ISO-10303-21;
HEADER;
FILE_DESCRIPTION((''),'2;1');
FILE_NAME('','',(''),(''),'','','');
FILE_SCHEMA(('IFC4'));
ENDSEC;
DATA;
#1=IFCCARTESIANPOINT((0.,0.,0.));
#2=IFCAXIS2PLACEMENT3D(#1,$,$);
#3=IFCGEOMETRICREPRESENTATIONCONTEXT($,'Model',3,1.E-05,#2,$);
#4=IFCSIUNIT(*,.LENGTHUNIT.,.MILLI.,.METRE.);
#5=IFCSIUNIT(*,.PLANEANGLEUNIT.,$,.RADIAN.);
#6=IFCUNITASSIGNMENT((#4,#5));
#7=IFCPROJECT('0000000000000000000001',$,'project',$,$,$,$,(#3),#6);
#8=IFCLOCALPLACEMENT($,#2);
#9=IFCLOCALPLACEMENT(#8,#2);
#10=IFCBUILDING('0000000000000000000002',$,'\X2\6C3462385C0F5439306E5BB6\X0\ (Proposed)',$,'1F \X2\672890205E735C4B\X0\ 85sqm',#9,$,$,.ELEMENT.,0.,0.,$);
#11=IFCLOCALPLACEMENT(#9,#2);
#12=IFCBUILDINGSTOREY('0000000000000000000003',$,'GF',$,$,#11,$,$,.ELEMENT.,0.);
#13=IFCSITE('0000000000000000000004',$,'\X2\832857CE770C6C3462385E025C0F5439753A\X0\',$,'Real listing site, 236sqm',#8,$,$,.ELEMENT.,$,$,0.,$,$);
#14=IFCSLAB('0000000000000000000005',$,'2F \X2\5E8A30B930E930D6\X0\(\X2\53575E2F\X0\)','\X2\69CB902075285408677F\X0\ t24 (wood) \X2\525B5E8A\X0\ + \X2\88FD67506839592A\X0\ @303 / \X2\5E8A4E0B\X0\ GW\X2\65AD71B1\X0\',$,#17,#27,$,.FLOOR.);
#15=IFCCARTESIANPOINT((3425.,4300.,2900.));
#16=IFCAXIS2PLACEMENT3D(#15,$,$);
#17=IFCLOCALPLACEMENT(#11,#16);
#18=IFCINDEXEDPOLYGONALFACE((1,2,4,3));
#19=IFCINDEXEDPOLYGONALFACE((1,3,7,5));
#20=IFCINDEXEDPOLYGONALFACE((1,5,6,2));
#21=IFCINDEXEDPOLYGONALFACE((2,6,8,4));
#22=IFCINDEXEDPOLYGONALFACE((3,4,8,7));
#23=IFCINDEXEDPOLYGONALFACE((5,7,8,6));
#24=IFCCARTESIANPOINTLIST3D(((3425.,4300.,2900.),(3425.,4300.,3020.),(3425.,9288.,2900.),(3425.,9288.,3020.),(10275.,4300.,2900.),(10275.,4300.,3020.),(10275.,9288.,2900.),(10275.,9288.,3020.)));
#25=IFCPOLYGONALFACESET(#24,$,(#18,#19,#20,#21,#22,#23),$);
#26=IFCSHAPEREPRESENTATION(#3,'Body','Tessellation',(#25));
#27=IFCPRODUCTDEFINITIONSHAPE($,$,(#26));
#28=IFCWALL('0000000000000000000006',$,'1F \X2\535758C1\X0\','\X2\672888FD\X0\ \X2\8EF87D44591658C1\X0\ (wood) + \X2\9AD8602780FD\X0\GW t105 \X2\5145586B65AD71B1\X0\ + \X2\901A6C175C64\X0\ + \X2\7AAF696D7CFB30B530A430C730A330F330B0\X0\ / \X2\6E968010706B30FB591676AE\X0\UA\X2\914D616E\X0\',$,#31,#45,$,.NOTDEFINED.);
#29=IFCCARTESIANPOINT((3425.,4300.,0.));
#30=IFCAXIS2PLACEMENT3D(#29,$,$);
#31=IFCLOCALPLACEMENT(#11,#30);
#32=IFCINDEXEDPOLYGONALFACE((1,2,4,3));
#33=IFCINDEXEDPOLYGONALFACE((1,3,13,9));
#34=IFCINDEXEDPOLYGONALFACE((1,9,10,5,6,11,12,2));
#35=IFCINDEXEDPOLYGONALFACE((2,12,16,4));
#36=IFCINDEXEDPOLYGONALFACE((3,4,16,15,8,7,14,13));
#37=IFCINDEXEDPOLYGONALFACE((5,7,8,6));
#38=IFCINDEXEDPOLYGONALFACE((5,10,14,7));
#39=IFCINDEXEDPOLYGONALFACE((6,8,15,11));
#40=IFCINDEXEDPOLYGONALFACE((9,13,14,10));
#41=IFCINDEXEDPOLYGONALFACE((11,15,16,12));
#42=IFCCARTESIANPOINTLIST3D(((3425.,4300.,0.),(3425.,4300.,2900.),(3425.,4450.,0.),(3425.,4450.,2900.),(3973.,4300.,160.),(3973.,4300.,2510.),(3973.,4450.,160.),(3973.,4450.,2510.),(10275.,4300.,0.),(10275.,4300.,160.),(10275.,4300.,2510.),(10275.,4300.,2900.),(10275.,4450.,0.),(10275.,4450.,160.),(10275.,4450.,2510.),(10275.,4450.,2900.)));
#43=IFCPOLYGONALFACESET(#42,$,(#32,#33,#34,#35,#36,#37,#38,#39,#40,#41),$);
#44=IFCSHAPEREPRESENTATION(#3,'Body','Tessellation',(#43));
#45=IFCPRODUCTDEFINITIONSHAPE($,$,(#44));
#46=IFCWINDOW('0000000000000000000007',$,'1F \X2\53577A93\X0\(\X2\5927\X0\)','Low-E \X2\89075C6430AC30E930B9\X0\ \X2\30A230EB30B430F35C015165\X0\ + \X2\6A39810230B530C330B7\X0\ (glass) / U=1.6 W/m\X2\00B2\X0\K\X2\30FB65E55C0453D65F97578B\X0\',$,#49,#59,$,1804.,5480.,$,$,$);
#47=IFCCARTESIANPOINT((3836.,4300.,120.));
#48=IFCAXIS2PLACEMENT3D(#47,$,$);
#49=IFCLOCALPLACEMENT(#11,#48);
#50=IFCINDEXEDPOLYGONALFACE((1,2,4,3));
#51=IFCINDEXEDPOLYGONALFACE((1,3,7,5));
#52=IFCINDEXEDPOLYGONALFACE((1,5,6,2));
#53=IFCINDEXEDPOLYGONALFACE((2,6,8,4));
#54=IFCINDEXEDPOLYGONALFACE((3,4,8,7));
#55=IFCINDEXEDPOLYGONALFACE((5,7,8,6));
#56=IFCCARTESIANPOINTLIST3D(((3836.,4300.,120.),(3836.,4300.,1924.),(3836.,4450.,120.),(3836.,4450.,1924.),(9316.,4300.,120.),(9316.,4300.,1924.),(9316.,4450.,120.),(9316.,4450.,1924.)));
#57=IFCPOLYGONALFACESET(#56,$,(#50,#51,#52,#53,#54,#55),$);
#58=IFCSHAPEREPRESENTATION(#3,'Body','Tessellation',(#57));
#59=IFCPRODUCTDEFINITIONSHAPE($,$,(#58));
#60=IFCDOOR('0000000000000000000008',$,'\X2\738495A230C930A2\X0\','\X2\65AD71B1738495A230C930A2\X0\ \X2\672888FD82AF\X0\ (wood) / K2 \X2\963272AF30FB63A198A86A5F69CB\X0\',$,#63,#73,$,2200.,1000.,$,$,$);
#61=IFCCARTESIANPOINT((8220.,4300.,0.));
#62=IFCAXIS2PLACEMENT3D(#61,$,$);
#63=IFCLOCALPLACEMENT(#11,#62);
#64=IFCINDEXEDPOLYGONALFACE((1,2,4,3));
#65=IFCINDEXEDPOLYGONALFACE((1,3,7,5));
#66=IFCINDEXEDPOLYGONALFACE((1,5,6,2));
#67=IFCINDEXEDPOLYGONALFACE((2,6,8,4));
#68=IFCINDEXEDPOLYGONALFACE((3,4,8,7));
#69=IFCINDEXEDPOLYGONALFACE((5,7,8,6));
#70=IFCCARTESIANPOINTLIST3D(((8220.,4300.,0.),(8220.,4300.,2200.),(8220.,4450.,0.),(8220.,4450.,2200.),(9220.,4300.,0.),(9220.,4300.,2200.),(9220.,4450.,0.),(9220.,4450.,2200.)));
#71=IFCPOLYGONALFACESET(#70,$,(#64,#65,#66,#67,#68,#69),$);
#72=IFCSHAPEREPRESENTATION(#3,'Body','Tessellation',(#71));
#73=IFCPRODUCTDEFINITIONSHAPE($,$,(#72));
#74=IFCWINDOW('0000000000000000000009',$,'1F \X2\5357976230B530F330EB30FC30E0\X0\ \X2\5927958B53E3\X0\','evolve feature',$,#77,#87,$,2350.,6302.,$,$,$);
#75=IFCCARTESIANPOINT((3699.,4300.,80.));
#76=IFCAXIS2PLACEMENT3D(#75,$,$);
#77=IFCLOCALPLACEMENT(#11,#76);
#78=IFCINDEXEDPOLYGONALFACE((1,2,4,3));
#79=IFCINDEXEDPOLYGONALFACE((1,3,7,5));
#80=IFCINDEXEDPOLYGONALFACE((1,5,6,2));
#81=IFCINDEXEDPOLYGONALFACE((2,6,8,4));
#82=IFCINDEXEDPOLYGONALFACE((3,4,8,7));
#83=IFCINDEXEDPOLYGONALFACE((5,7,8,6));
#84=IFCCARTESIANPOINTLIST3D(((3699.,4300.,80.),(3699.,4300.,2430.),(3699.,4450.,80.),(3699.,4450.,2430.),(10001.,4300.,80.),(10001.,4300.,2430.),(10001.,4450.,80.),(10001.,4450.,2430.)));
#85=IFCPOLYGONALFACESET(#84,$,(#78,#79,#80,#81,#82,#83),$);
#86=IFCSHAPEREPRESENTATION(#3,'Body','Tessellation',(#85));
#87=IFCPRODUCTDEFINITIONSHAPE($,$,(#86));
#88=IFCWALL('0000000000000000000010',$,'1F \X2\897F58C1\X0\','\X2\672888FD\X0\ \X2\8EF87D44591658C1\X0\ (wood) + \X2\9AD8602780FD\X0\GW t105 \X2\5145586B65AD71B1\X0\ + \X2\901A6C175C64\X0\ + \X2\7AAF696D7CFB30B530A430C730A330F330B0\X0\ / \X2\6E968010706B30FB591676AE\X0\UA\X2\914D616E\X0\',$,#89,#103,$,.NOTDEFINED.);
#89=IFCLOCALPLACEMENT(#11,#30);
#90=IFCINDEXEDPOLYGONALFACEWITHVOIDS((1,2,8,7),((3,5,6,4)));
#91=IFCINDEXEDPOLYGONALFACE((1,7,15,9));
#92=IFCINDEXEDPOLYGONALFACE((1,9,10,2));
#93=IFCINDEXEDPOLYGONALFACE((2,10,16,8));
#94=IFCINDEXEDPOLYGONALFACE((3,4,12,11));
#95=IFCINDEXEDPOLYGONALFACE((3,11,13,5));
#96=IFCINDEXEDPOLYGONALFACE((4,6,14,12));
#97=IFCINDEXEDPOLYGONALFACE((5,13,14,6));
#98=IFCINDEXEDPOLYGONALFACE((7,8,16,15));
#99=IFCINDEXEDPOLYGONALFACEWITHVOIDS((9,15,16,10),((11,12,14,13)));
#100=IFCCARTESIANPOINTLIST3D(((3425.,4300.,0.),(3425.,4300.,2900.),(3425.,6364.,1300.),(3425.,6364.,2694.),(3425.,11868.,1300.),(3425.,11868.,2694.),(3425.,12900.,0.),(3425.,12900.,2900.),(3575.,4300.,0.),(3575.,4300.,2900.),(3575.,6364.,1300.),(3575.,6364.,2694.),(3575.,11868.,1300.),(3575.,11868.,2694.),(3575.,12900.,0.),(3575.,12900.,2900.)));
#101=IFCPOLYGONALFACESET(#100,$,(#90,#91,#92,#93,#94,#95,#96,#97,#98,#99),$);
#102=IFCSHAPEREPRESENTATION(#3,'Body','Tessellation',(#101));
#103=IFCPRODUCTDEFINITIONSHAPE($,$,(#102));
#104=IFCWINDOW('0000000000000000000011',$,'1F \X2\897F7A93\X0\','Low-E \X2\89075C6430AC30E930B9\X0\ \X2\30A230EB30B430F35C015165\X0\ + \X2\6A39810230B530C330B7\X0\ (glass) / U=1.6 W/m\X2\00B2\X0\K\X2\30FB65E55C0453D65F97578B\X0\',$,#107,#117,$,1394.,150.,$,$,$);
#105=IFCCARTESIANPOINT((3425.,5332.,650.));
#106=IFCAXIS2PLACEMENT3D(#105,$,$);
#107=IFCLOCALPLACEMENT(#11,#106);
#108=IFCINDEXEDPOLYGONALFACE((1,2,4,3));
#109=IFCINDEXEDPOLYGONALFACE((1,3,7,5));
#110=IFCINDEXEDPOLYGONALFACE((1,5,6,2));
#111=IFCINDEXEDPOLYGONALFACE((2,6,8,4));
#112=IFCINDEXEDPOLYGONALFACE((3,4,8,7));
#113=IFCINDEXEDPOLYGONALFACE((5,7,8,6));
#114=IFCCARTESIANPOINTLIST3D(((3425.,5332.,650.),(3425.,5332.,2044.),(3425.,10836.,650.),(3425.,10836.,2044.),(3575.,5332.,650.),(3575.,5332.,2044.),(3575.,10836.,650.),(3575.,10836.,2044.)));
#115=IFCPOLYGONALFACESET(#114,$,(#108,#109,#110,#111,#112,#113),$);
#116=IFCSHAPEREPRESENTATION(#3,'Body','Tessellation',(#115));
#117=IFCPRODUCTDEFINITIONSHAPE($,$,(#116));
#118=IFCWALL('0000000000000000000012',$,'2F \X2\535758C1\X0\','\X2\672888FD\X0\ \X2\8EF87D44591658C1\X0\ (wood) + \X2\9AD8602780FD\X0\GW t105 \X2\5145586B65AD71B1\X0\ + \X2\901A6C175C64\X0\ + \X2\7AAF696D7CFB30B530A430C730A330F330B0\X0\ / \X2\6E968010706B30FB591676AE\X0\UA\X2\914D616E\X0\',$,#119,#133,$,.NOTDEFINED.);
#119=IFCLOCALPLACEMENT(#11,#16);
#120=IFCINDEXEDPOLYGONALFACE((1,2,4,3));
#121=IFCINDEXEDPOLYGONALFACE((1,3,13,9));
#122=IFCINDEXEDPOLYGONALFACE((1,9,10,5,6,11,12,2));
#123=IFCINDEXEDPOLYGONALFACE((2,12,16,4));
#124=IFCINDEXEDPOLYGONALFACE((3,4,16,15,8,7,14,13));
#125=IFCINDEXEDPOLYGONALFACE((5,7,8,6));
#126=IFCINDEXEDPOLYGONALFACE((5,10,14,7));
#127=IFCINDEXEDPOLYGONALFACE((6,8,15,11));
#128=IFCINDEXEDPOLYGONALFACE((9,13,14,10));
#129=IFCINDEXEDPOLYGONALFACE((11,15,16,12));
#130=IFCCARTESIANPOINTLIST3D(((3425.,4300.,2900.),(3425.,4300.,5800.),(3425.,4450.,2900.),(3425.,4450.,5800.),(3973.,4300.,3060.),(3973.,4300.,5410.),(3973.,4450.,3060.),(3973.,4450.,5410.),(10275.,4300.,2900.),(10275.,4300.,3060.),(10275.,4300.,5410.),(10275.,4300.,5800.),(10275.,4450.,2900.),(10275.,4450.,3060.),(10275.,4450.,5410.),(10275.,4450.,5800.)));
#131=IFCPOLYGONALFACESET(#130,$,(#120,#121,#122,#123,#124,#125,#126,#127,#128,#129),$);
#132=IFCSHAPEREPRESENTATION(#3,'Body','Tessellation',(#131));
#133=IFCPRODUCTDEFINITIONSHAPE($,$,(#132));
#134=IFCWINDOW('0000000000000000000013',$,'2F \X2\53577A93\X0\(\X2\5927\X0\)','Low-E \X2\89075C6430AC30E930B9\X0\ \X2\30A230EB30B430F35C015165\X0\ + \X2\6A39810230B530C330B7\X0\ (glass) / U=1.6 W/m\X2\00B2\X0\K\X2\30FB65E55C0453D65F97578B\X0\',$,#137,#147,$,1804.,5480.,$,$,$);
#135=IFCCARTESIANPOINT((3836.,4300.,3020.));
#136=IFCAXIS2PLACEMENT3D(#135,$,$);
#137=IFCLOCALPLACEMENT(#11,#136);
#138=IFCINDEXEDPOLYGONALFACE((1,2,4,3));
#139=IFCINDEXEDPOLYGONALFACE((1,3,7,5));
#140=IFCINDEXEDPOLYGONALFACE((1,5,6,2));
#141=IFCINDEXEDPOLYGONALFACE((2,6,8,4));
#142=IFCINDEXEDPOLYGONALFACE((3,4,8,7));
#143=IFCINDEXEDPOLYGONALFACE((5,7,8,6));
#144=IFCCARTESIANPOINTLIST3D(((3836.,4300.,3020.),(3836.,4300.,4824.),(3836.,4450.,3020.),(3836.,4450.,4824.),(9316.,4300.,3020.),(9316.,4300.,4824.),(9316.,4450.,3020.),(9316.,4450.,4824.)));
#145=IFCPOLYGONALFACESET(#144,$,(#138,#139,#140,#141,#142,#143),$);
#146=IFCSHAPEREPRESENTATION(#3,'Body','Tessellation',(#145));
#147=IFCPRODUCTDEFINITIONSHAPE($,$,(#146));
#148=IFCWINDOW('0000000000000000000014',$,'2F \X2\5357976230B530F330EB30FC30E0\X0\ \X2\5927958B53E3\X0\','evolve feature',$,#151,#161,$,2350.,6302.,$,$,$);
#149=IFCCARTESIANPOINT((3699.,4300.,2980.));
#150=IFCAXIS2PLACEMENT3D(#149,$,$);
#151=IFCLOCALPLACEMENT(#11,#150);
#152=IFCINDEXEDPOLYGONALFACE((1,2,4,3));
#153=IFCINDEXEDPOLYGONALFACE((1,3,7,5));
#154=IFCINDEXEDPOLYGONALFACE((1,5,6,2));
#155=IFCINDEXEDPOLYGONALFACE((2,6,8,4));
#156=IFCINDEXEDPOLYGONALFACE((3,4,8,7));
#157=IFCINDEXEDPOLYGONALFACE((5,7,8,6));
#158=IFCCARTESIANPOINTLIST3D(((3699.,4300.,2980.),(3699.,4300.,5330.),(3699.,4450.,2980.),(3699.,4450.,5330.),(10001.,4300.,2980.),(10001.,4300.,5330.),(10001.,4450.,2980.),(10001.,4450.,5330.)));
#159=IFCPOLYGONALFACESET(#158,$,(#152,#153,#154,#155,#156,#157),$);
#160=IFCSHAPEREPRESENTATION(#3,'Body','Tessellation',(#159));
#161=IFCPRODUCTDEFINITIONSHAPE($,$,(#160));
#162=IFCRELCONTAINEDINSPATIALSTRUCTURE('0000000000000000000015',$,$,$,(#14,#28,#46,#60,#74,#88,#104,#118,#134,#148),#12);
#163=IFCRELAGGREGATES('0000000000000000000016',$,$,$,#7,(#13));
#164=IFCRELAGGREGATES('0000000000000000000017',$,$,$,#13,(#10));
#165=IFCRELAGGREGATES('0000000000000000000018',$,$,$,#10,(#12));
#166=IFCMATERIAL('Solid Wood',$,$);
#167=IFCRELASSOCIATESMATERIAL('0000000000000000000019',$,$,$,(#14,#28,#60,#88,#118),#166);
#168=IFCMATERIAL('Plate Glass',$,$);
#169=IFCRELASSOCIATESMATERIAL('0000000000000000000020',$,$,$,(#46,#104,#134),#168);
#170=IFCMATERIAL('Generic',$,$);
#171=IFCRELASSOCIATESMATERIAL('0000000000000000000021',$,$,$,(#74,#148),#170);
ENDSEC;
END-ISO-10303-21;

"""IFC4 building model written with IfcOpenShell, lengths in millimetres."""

from ifc_helpers import new_model, si_unit, frame, frame_2d, origin, place, context, project, spatial, rectangle, extrude, material, element, fill, save


model = new_model("IFC4")

# Units and contexts
model_context = context("Model", 3, precision=1e-05, world=origin())
ifc_project = project(units=[si_unit("LENGTHUNIT", "METRE", prefix="MILLI"), si_unit("PLANEANGLEUNIT", "RADIAN")], contexts=[model_context])

# Site, building, storey
site_placement = place(None, origin())
site = spatial("IfcSite", under=ifc_project, at=site_placement, Name="茨城県水戸市小吹町", ObjectType="Real listing site, 236sqm", CompositionType="ELEMENT", RefElevation=0.0)
building_placement = place(site_placement, origin())
building = spatial("IfcBuilding", under=site, at=building_placement, Name="水戸小吹の家 (Proposed)", ObjectType="1F 木造平屋 85sqm", CompositionType="ELEMENT", ElevationOfRefHeight=0.0, ElevationOfTerrain=0.0)
storey_placement = place(building_placement, origin())
storey = spatial("IfcBuildingStorey", under=building, at=storey_placement, Name="GF", CompositionType="ELEMENT", Elevation=0.0)

# Slab
ifc_material_1 = material(Name="Solid Wood")
slab_1_placement = place(storey_placement, frame((3425.0, 4300.0, 2900.0)))
element("IfcSlab", 1, at=slab_1_placement, inside=storey, material=ifc_material_1, Name="2F 床スラブ(南帯)", Description="構造用合板 t24 (wood) 剛床 + 製材根太 @303 / 床下 GW断熱", PredefinedType="FLOOR", context=model_context, shape_type="SweptSolid", body=[
    extrude(rectangle(XDim=6850.0, YDim=4988.0, at=frame_2d((3425.0, 2494.0))), frame((3425.0, 4300.0, 2900.0)), (0.0, 0.0, 1.0), 120.0),
])
ifc_material_2 = material(Name="Generic")

# Wall, openings, windows, door
wall_1_placement = place(storey_placement, frame((3425.0, 4300.0, 0.0)))
wall_1 = element("IfcWall", 2, at=wall_1_placement, inside=storey, material=ifc_material_1, Name="1F 南壁", Description="木製 軸組外壁 (wood) + 高性能GW t105 充填断熱 + 通気層 + 窯業系サイディング / 準耐火・外皮UA配慮", PredefinedType="NOTDEFINED", context=model_context, shape_type="SweptSolid", body=[
    extrude(rectangle(XDim=6850.0, YDim=150.0, at=frame_2d((3425.0, 75.0))), frame((3425.0, 4300.0, 0.0)), (0.0, 0.0, 1.0), 2900.0),
])
opening_1_placement = place(storey_placement, frame((3836.0, 4300.0, 120.0)))
opening_1 = element("IfcOpeningElement", 3, at=opening_1_placement, cuts=wall_1, PredefinedType="NOTDEFINED", context=model_context, shape_type="SweptSolid", body=[
    extrude(rectangle(XDim=5480.0, YDim=150.0, at=frame_2d((2740.0, 75.0))), frame((3836.0, 4300.0, 120.0)), (0.0, 0.0, 1.0), 1804.0),
])
opening_2_placement = place(storey_placement, frame((8220.0, 4300.0, 0.0)))
opening_2 = element("IfcOpeningElement", 4, at=opening_2_placement, cuts=wall_1, PredefinedType="NOTDEFINED", context=model_context, shape_type="SweptSolid", body=[
    extrude(rectangle(XDim=1000.0, YDim=150.0, at=frame_2d((500.0, 75.0))), frame((8220.0, 4300.0, 0.0)), (0.0, 0.0, 1.0), 2200.0),
])
opening_3_placement = place(storey_placement, frame((3699.0, 4300.0, 80.0)))
opening_3 = element("IfcOpeningElement", 5, at=opening_3_placement, cuts=wall_1, PredefinedType="NOTDEFINED", context=model_context, shape_type="SweptSolid", body=[
    extrude(rectangle(XDim=6302.0, YDim=150.0, at=frame_2d((3151.0, 75.0))), frame((3699.0, 4300.0, 80.0)), (0.0, 0.0, 1.0), 2350.0),
])
ifc_material_3 = material(Name="Plate Glass")
window_1_placement = place(storey_placement, frame((3836.0, 4300.0, 120.0)))
window_1 = element("IfcWindow", 6, at=window_1_placement, inside=storey, material=ifc_material_3, Name="1F 南窓(大)", Description="Low-E 複層ガラス アルゴン封入 + 樹脂サッシ (glass) / U=1.6 W/m²K・日射取得型", OverallHeight=1804.0, OverallWidth=5480.0, context=model_context, shape_type="SweptSolid", body=[
    extrude(rectangle(XDim=5480.0, YDim=150.0, at=frame_2d((2740.0, 75.0))), frame((3836.0, 4300.0, 120.0)), (0.0, 0.0, 1.0), 1804.0),
])
fill(opening_1, window_1)
door_placement = place(storey_placement, frame((8220.0, 4300.0, 0.0)))
door = element("IfcDoor", 7, at=door_placement, inside=storey, material=ifc_material_1, Name="玄関ドア", Description="断熱玄関ドア 木製芯 (wood) / K2 防犯・採風機構", OverallHeight=2200.0, OverallWidth=1000.0, context=model_context, shape_type="SweptSolid", body=[
    extrude(rectangle(XDim=1000.0, YDim=150.0, at=frame_2d((500.0, 75.0))), frame((8220.0, 4300.0, 0.0)), (0.0, 0.0, 1.0), 2200.0),
])
fill(opening_2, door)
window_2_placement = place(storey_placement, frame((3699.0, 4300.0, 80.0)))
window_2 = element("IfcWindow", 8, at=window_2_placement, inside=storey, material=ifc_material_2, Name="1F 南面サンルーム 大開口", Description="evolve feature", OverallHeight=2350.0, OverallWidth=6302.0, context=model_context, shape_type="SweptSolid", body=[
    extrude(rectangle(XDim=6302.0, YDim=150.0, at=frame_2d((3151.0, 75.0))), frame((3699.0, 4300.0, 80.0)), (0.0, 0.0, 1.0), 2350.0),
])
fill(opening_3, window_2)

# Wall, opening, window
wall_2_placement = place(storey_placement, frame((3425.0, 4300.0, 0.0)))
wall_2 = element("IfcWall", 9, at=wall_2_placement, inside=storey, material=ifc_material_1, Name="1F 西壁", Description="木製 軸組外壁 (wood) + 高性能GW t105 充填断熱 + 通気層 + 窯業系サイディング / 準耐火・外皮UA配慮", PredefinedType="NOTDEFINED", context=model_context, shape_type="SweptSolid", body=[
    extrude(rectangle(XDim=150.0, YDim=8600.0, at=frame_2d((75.0, 4300.0))), frame((3425.0, 4300.0, 0.0)), (0.0, 0.0, 1.0), 2900.0),
])
opening_4_placement = place(storey_placement, frame((3425.0, 5332.0, 650.0)))
opening_4 = element("IfcOpeningElement", 10, at=opening_4_placement, cuts=wall_2, PredefinedType="NOTDEFINED", context=model_context, shape_type="SweptSolid", body=[
    extrude(rectangle(XDim=150.0, YDim=5504.0, at=frame_2d((75.0, 2752.0))), frame((3425.0, 5332.0, 650.0)), (0.0, 0.0, 1.0), 1394.0),
])
window_3_placement = place(storey_placement, frame((3425.0, 5332.0, 650.0)))
window_3 = element("IfcWindow", 11, at=window_3_placement, inside=storey, material=ifc_material_3, Name="1F 西窓", Description="Low-E 複層ガラス アルゴン封入 + 樹脂サッシ (glass) / U=1.6 W/m²K・日射取得型", OverallHeight=1394.0, OverallWidth=150.0, context=model_context, shape_type="SweptSolid", body=[
    extrude(rectangle(XDim=150.0, YDim=5504.0, at=frame_2d((75.0, 2752.0))), frame((3425.0, 5332.0, 650.0)), (0.0, 0.0, 1.0), 1394.0),
])
fill(opening_4, window_3)

# Wall, openings, windows
wall_3_placement = place(storey_placement, frame((3425.0, 4300.0, 2900.0)))
wall_3 = element("IfcWall", 12, at=wall_3_placement, inside=storey, material=ifc_material_1, Name="2F 南壁", Description="木製 軸組外壁 (wood) + 高性能GW t105 充填断熱 + 通気層 + 窯業系サイディング / 準耐火・外皮UA配慮", PredefinedType="NOTDEFINED", context=model_context, shape_type="SweptSolid", body=[
    extrude(rectangle(XDim=6850.0, YDim=150.0, at=frame_2d((3425.0, 75.0))), frame((3425.0, 4300.0, 2900.0)), (0.0, 0.0, 1.0), 2900.0),
])
opening_5_placement = place(storey_placement, frame((3836.0, 4300.0, 3020.0)))
opening_5 = element("IfcOpeningElement", 13, at=opening_5_placement, cuts=wall_3, PredefinedType="NOTDEFINED", context=model_context, shape_type="SweptSolid", body=[
    extrude(rectangle(XDim=5480.0, YDim=150.0, at=frame_2d((2740.0, 75.0))), frame((3836.0, 4300.0, 3020.0)), (0.0, 0.0, 1.0), 1804.0),
])
opening_6_placement = place(storey_placement, frame((3699.0, 4300.0, 2980.0)))
opening_6 = element("IfcOpeningElement", 14, at=opening_6_placement, cuts=wall_3, PredefinedType="NOTDEFINED", context=model_context, shape_type="SweptSolid", body=[
    extrude(rectangle(XDim=6302.0, YDim=150.0, at=frame_2d((3151.0, 75.0))), frame((3699.0, 4300.0, 2980.0)), (0.0, 0.0, 1.0), 2350.0),
])
window_4_placement = place(storey_placement, frame((3836.0, 4300.0, 3020.0)))
window_4 = element("IfcWindow", 15, at=window_4_placement, inside=storey, material=ifc_material_3, Name="2F 南窓(大)", Description="Low-E 複層ガラス アルゴン封入 + 樹脂サッシ (glass) / U=1.6 W/m²K・日射取得型", OverallHeight=1804.0, OverallWidth=5480.0, context=model_context, shape_type="SweptSolid", body=[
    extrude(rectangle(XDim=5480.0, YDim=150.0, at=frame_2d((2740.0, 75.0))), frame((3836.0, 4300.0, 3020.0)), (0.0, 0.0, 1.0), 1804.0),
])
fill(opening_5, window_4)
window_5_placement = place(storey_placement, frame((3699.0, 4300.0, 2980.0)))
window_5 = element("IfcWindow", 16, at=window_5_placement, inside=storey, material=ifc_material_2, Name="2F 南面サンルーム 大開口", Description="evolve feature", OverallHeight=2350.0, OverallWidth=6302.0, context=model_context, shape_type="SweptSolid", body=[
    extrude(rectangle(XDim=6302.0, YDim=150.0, at=frame_2d((3151.0, 75.0))), frame((3699.0, 4300.0, 2980.0)), (0.0, 0.0, 1.0), 2350.0),
])
fill(opening_6, window_5)

save(model, "model.ifc")
